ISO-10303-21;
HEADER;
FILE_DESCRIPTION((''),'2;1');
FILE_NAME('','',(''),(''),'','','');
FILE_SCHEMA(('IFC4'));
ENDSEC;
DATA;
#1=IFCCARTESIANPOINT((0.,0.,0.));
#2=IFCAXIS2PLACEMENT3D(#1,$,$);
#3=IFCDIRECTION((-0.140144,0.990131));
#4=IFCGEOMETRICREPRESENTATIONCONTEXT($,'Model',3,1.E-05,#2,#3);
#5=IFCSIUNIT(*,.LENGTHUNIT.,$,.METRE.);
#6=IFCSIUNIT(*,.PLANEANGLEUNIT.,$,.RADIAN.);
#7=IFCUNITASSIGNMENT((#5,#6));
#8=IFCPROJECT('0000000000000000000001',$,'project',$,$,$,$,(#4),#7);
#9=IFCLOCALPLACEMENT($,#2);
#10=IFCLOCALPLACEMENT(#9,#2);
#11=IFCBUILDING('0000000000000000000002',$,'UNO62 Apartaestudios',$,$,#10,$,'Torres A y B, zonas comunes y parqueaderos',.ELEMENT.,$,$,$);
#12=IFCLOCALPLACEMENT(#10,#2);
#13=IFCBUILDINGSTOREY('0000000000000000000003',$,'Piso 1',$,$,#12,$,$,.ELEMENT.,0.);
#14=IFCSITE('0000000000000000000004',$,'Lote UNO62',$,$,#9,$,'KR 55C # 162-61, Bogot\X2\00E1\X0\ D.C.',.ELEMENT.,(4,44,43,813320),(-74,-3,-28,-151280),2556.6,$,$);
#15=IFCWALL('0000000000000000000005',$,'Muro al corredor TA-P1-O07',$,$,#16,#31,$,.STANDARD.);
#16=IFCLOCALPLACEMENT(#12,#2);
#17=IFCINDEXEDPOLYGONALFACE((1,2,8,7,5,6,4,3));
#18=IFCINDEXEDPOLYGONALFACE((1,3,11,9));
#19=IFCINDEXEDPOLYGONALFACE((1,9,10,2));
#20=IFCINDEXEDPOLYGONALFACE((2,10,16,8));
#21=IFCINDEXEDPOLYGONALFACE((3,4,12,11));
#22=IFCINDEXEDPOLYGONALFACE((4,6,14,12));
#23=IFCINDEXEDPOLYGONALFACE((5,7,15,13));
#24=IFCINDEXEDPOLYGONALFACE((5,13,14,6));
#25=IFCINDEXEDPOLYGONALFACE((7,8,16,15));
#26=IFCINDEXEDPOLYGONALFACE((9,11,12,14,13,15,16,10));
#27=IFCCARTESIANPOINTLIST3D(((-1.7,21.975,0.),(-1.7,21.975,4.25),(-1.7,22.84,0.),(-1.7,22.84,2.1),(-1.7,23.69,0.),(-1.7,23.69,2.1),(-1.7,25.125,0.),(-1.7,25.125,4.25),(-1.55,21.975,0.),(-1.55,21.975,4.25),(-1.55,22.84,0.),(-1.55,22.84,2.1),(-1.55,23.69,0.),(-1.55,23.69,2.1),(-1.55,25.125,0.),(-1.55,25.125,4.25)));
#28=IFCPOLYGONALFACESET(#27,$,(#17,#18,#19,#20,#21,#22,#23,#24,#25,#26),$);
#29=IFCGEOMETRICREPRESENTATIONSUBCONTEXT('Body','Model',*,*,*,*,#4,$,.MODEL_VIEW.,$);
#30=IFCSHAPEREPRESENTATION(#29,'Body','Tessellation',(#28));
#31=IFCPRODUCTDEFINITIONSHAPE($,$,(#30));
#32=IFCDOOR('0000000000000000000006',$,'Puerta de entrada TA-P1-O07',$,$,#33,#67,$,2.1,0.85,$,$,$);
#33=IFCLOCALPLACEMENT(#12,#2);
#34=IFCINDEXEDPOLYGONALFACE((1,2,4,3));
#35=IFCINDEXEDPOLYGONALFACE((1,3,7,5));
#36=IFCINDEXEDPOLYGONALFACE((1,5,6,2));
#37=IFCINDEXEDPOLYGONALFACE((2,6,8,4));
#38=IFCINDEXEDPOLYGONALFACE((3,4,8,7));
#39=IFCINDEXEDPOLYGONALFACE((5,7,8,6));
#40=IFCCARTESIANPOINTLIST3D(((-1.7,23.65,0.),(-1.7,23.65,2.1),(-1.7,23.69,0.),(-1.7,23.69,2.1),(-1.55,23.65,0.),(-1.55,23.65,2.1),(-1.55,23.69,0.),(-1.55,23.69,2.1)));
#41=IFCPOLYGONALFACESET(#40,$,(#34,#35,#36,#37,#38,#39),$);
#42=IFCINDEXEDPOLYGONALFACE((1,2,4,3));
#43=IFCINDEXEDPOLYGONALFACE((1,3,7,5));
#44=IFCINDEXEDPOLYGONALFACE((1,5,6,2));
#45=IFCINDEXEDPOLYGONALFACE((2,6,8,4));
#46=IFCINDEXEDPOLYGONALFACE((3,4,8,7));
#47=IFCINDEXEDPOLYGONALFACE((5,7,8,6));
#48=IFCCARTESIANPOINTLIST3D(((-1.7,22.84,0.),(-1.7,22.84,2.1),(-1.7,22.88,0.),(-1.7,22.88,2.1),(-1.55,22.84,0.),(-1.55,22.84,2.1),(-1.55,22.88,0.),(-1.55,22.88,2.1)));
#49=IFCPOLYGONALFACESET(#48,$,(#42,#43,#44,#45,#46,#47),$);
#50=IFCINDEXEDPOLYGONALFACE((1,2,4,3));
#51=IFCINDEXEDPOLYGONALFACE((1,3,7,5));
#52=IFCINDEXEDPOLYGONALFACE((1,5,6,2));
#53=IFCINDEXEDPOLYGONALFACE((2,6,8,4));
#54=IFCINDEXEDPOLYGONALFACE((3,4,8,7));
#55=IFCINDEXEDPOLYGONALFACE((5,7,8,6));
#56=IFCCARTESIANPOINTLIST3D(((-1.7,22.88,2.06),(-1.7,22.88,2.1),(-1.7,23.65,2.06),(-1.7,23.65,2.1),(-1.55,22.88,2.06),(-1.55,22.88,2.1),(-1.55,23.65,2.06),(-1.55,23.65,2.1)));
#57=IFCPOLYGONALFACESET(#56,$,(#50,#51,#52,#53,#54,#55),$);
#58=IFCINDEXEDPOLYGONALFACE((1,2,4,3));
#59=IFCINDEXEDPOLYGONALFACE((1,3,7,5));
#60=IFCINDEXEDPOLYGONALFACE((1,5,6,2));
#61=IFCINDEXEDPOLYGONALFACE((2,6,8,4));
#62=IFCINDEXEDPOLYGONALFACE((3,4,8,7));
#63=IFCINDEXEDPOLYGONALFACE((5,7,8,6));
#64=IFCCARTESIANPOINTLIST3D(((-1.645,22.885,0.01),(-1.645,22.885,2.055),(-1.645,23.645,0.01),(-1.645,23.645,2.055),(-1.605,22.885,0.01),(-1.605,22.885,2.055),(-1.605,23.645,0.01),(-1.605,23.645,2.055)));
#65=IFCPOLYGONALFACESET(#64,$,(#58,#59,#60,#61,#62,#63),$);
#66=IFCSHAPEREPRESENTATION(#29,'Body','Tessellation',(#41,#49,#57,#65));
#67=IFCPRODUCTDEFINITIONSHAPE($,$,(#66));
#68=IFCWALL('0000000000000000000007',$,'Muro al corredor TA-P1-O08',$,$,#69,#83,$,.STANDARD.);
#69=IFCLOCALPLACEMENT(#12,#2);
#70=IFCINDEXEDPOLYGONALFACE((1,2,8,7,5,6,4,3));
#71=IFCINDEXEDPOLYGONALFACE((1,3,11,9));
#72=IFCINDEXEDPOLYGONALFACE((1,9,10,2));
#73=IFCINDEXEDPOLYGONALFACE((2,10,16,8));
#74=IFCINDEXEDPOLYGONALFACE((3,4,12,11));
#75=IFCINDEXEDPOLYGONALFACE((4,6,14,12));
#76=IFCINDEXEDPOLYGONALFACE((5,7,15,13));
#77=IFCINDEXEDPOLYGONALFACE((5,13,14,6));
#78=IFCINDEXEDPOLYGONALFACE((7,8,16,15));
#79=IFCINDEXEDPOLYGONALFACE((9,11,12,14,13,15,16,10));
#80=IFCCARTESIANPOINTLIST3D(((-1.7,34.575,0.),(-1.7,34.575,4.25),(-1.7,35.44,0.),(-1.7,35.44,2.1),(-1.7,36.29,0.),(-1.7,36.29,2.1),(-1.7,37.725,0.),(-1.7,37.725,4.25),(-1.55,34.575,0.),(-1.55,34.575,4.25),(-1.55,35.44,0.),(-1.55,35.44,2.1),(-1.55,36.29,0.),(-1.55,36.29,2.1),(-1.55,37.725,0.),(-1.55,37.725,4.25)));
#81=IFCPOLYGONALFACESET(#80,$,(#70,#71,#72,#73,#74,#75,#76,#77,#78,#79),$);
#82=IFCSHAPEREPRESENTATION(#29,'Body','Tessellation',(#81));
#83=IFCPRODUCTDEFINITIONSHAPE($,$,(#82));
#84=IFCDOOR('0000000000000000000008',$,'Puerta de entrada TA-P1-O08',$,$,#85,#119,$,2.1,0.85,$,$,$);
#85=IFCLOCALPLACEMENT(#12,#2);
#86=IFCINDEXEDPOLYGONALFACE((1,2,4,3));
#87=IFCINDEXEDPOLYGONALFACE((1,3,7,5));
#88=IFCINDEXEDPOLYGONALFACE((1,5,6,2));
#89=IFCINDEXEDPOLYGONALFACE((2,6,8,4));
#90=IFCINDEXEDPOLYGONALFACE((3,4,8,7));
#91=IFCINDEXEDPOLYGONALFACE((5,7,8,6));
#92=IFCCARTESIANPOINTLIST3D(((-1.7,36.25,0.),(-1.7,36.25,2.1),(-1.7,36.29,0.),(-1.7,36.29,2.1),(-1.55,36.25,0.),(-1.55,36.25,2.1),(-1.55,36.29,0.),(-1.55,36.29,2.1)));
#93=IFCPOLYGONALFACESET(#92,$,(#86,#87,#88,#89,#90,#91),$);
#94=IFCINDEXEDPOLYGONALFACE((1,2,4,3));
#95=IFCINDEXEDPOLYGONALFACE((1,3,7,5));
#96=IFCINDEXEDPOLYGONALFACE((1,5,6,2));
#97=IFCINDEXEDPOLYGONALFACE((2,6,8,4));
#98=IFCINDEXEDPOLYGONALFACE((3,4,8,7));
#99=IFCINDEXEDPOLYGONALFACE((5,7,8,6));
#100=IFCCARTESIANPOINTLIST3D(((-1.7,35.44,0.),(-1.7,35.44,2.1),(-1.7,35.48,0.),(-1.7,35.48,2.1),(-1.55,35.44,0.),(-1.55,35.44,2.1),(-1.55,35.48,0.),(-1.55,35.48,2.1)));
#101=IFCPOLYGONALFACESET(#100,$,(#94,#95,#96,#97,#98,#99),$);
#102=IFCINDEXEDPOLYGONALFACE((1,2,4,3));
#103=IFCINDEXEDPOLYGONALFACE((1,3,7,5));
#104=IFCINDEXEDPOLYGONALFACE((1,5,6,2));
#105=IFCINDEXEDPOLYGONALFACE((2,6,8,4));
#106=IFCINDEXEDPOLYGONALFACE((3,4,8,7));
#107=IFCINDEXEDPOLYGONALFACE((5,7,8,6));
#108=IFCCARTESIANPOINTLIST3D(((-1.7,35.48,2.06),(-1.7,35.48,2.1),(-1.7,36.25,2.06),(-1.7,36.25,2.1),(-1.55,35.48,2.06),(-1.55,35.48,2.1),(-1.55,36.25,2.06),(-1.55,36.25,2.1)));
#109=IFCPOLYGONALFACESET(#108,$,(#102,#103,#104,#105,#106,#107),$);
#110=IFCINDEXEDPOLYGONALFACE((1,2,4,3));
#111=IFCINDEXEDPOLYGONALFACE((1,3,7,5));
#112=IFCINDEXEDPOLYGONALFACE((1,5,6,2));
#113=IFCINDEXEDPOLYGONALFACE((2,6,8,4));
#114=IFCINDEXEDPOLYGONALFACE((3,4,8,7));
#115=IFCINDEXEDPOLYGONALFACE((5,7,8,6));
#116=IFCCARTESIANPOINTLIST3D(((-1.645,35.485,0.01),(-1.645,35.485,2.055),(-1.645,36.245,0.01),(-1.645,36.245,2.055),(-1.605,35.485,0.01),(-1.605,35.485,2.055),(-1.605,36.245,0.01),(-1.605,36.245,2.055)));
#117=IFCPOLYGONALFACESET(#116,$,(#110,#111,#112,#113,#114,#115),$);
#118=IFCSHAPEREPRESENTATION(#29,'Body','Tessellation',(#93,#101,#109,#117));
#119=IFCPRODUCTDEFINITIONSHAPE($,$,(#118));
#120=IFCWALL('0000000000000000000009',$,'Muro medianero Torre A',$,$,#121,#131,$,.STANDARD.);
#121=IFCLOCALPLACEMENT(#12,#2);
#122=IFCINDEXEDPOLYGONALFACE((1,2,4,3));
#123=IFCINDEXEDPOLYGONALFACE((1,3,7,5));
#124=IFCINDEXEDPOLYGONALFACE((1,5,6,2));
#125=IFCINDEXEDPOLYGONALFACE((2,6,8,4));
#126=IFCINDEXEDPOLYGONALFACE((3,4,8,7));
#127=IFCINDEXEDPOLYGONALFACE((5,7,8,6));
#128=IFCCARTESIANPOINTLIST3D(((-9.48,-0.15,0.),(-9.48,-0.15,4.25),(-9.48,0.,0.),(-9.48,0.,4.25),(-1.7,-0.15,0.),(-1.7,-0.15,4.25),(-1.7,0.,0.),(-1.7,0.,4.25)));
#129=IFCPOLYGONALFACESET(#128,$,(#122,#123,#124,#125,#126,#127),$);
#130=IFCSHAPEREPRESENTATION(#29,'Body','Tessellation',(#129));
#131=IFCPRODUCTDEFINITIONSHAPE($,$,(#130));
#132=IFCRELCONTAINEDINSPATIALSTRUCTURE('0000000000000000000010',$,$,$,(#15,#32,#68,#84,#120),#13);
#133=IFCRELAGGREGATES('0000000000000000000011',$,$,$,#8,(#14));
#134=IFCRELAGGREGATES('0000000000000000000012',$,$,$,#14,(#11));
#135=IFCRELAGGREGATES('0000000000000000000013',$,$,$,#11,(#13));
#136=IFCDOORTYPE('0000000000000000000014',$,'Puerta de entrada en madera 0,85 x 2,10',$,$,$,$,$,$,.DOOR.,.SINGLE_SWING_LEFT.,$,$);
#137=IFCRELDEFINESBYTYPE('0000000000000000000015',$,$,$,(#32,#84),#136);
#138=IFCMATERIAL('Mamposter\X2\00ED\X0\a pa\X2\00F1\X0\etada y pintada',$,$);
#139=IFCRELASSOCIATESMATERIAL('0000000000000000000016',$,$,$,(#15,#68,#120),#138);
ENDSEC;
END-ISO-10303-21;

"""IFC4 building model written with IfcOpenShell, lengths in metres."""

from ifc_helpers import new_model, si_unit, direction, frame, frame_2d, origin, place, context, subcontext, project, spatial, rectangle, extrude, source, transform, mapped, material, type_object, type_shapes, element, fill, save


model = new_model("IFC4")

# Units and contexts
model_context = context("Model", 3, precision=1e-05, world=origin(), true_north=direction((-0.140144, 0.990131)))
body_context = subcontext(model_context, "Body", "Model", "MODEL_VIEW")
ifc_project = project(units=[si_unit("LENGTHUNIT", "METRE"), si_unit("PLANEANGLEUNIT", "RADIAN")], contexts=[model_context])

# Site, building, storey
site_placement = place(None, origin())
site = spatial("IfcSite", under=ifc_project, at=site_placement, Name="Lote UNO62", LongName="KR 55C # 162-61, Bogotá D.C.", CompositionType="ELEMENT", RefLatitude=(4, 44, 43, 813320), RefLongitude=(-74, -3, -28, -151280), RefElevation=2556.6)
building_placement = place(site_placement, origin())
building = spatial("IfcBuilding", under=site, at=building_placement, Name="UNO62 Apartaestudios", LongName="Torres A y B, zonas comunes y parqueaderos", CompositionType="ELEMENT")
storey_placement = place(building_placement, origin())
storey = spatial("IfcBuildingStorey", under=building, at=storey_placement, Name="Piso 1", CompositionType="ELEMENT", Elevation=0.0)

# Walls, openings, doors
ifc_material = material(Name="Mampostería pañetada y pintada")
door_type = type_object("IfcDoorType", Name="Puerta de entrada en madera 0,85 x 2,10", OperationType="SINGLE_SWING_LEFT", PredefinedType="DOOR")
shared_shape = source(origin(), body_context, "Body", "SweptSolid", [
    extrude(rectangle(XDim=0.15, YDim=0.04, at=frame_2d((-0.075, 1.38))), origin(), (0.0, 0.0, 1.0), 2.1),
    extrude(rectangle(XDim=0.15, YDim=0.04, at=frame_2d((-0.075, 2.19))), origin(), (0.0, 0.0, 1.0), 2.1),
    extrude(rectangle(XDim=0.15, YDim=0.77, at=frame_2d((-0.075, 1.785))), frame((0.0, 0.0, 2.06)), (0.0, 0.0, 1.0), 0.04),
    extrude(rectangle(XDim=0.04, YDim=0.76, at=frame_2d((-0.075, 1.785))), frame((0.0, 0.0, 0.01)), (0.0, 0.0, 1.0), 2.045),
])
type_shapes(door_type, [shared_shape])
wall_1_placement = place(storey_placement, origin())
wall_1 = element("IfcWall", 1, at=wall_1_placement, inside=storey, material=ifc_material, Name="Muro al corredor TA-P1-O07", PredefinedType="STANDARD", context=body_context, shape_type="SweptSolid", body=[
    extrude(rectangle(XDim=0.15, YDim=3.15, at=frame_2d((-1.625, 23.55))), origin(), (0.0, 0.0, 1.0), 4.25),
])
opening_1_placement = place(wall_1_placement, origin())
opening_1 = element("IfcOpeningElement", 2, at=opening_1_placement, cuts=wall_1, PredefinedType="OPENING", context=body_context, shape_type="SweptSolid", body=[
    extrude(rectangle(XDim=0.25, YDim=0.85, at=frame_2d((-1.625, 23.265))), origin(), (0.0, 0.0, 1.0), 2.1),
])
placement_1 = place(storey_placement, frame((-1.7, 25.05, 0.0), z_axis=(0.0, 0.0, 1.0), x_axis=(-1.0, 0.0, 0.0)))
door_1_placement = place(placement_1, origin())
door_1 = element("IfcDoor", 3, at=door_1_placement, inside=storey, type_object=door_type, Name="Puerta de entrada TA-P1-O07", OverallHeight=2.1, OverallWidth=0.85, context=body_context, shape_type="MappedRepresentation", body=[
    mapped(shared_shape, transform((0.0, 0.0, 0.0))),
])
fill(opening_1, door_1)
wall_2_placement = place(storey_placement, origin())
wall_2 = element("IfcWall", 4, at=wall_2_placement, inside=storey, material=ifc_material, Name="Muro al corredor TA-P1-O08", PredefinedType="STANDARD", context=body_context, shape_type="SweptSolid", body=[
    extrude(rectangle(XDim=0.15, YDim=3.15, at=frame_2d((-1.625, 36.15))), origin(), (0.0, 0.0, 1.0), 4.25),
])
opening_2_placement = place(wall_2_placement, origin())
opening_2 = element("IfcOpeningElement", 5, at=opening_2_placement, cuts=wall_2, PredefinedType="OPENING", context=body_context, shape_type="SweptSolid", body=[
    extrude(rectangle(XDim=0.25, YDim=0.85, at=frame_2d((-1.625, 35.865))), origin(), (0.0, 0.0, 1.0), 2.1),
])
placement_2 = place(storey_placement, frame((-1.7, 37.65, 0.0), z_axis=(0.0, 0.0, 1.0), x_axis=(-1.0, 0.0, 0.0)))
door_2_placement = place(placement_2, origin())
door_2 = element("IfcDoor", 6, at=door_2_placement, inside=storey, type_object=door_type, Name="Puerta de entrada TA-P1-O08", OverallHeight=2.1, OverallWidth=0.85, context=body_context, shape_type="MappedRepresentation", body=[
    mapped(shared_shape, transform((0.0, 0.0, 0.0))),
])
fill(opening_2, door_2)

# Wall
wall_3_placement = place(storey_placement, origin())
element("IfcWall", 7, at=wall_3_placement, inside=storey, material=ifc_material, Name="Muro medianero Torre A", PredefinedType="STANDARD", context=body_context, shape_type="SweptSolid", body=[
    extrude(rectangle(XDim=7.78, YDim=0.15, at=frame_2d((-5.59, -0.075))), origin(), (0.0, 0.0, 1.0), 4.25),
])

save(model, "model.ifc")
